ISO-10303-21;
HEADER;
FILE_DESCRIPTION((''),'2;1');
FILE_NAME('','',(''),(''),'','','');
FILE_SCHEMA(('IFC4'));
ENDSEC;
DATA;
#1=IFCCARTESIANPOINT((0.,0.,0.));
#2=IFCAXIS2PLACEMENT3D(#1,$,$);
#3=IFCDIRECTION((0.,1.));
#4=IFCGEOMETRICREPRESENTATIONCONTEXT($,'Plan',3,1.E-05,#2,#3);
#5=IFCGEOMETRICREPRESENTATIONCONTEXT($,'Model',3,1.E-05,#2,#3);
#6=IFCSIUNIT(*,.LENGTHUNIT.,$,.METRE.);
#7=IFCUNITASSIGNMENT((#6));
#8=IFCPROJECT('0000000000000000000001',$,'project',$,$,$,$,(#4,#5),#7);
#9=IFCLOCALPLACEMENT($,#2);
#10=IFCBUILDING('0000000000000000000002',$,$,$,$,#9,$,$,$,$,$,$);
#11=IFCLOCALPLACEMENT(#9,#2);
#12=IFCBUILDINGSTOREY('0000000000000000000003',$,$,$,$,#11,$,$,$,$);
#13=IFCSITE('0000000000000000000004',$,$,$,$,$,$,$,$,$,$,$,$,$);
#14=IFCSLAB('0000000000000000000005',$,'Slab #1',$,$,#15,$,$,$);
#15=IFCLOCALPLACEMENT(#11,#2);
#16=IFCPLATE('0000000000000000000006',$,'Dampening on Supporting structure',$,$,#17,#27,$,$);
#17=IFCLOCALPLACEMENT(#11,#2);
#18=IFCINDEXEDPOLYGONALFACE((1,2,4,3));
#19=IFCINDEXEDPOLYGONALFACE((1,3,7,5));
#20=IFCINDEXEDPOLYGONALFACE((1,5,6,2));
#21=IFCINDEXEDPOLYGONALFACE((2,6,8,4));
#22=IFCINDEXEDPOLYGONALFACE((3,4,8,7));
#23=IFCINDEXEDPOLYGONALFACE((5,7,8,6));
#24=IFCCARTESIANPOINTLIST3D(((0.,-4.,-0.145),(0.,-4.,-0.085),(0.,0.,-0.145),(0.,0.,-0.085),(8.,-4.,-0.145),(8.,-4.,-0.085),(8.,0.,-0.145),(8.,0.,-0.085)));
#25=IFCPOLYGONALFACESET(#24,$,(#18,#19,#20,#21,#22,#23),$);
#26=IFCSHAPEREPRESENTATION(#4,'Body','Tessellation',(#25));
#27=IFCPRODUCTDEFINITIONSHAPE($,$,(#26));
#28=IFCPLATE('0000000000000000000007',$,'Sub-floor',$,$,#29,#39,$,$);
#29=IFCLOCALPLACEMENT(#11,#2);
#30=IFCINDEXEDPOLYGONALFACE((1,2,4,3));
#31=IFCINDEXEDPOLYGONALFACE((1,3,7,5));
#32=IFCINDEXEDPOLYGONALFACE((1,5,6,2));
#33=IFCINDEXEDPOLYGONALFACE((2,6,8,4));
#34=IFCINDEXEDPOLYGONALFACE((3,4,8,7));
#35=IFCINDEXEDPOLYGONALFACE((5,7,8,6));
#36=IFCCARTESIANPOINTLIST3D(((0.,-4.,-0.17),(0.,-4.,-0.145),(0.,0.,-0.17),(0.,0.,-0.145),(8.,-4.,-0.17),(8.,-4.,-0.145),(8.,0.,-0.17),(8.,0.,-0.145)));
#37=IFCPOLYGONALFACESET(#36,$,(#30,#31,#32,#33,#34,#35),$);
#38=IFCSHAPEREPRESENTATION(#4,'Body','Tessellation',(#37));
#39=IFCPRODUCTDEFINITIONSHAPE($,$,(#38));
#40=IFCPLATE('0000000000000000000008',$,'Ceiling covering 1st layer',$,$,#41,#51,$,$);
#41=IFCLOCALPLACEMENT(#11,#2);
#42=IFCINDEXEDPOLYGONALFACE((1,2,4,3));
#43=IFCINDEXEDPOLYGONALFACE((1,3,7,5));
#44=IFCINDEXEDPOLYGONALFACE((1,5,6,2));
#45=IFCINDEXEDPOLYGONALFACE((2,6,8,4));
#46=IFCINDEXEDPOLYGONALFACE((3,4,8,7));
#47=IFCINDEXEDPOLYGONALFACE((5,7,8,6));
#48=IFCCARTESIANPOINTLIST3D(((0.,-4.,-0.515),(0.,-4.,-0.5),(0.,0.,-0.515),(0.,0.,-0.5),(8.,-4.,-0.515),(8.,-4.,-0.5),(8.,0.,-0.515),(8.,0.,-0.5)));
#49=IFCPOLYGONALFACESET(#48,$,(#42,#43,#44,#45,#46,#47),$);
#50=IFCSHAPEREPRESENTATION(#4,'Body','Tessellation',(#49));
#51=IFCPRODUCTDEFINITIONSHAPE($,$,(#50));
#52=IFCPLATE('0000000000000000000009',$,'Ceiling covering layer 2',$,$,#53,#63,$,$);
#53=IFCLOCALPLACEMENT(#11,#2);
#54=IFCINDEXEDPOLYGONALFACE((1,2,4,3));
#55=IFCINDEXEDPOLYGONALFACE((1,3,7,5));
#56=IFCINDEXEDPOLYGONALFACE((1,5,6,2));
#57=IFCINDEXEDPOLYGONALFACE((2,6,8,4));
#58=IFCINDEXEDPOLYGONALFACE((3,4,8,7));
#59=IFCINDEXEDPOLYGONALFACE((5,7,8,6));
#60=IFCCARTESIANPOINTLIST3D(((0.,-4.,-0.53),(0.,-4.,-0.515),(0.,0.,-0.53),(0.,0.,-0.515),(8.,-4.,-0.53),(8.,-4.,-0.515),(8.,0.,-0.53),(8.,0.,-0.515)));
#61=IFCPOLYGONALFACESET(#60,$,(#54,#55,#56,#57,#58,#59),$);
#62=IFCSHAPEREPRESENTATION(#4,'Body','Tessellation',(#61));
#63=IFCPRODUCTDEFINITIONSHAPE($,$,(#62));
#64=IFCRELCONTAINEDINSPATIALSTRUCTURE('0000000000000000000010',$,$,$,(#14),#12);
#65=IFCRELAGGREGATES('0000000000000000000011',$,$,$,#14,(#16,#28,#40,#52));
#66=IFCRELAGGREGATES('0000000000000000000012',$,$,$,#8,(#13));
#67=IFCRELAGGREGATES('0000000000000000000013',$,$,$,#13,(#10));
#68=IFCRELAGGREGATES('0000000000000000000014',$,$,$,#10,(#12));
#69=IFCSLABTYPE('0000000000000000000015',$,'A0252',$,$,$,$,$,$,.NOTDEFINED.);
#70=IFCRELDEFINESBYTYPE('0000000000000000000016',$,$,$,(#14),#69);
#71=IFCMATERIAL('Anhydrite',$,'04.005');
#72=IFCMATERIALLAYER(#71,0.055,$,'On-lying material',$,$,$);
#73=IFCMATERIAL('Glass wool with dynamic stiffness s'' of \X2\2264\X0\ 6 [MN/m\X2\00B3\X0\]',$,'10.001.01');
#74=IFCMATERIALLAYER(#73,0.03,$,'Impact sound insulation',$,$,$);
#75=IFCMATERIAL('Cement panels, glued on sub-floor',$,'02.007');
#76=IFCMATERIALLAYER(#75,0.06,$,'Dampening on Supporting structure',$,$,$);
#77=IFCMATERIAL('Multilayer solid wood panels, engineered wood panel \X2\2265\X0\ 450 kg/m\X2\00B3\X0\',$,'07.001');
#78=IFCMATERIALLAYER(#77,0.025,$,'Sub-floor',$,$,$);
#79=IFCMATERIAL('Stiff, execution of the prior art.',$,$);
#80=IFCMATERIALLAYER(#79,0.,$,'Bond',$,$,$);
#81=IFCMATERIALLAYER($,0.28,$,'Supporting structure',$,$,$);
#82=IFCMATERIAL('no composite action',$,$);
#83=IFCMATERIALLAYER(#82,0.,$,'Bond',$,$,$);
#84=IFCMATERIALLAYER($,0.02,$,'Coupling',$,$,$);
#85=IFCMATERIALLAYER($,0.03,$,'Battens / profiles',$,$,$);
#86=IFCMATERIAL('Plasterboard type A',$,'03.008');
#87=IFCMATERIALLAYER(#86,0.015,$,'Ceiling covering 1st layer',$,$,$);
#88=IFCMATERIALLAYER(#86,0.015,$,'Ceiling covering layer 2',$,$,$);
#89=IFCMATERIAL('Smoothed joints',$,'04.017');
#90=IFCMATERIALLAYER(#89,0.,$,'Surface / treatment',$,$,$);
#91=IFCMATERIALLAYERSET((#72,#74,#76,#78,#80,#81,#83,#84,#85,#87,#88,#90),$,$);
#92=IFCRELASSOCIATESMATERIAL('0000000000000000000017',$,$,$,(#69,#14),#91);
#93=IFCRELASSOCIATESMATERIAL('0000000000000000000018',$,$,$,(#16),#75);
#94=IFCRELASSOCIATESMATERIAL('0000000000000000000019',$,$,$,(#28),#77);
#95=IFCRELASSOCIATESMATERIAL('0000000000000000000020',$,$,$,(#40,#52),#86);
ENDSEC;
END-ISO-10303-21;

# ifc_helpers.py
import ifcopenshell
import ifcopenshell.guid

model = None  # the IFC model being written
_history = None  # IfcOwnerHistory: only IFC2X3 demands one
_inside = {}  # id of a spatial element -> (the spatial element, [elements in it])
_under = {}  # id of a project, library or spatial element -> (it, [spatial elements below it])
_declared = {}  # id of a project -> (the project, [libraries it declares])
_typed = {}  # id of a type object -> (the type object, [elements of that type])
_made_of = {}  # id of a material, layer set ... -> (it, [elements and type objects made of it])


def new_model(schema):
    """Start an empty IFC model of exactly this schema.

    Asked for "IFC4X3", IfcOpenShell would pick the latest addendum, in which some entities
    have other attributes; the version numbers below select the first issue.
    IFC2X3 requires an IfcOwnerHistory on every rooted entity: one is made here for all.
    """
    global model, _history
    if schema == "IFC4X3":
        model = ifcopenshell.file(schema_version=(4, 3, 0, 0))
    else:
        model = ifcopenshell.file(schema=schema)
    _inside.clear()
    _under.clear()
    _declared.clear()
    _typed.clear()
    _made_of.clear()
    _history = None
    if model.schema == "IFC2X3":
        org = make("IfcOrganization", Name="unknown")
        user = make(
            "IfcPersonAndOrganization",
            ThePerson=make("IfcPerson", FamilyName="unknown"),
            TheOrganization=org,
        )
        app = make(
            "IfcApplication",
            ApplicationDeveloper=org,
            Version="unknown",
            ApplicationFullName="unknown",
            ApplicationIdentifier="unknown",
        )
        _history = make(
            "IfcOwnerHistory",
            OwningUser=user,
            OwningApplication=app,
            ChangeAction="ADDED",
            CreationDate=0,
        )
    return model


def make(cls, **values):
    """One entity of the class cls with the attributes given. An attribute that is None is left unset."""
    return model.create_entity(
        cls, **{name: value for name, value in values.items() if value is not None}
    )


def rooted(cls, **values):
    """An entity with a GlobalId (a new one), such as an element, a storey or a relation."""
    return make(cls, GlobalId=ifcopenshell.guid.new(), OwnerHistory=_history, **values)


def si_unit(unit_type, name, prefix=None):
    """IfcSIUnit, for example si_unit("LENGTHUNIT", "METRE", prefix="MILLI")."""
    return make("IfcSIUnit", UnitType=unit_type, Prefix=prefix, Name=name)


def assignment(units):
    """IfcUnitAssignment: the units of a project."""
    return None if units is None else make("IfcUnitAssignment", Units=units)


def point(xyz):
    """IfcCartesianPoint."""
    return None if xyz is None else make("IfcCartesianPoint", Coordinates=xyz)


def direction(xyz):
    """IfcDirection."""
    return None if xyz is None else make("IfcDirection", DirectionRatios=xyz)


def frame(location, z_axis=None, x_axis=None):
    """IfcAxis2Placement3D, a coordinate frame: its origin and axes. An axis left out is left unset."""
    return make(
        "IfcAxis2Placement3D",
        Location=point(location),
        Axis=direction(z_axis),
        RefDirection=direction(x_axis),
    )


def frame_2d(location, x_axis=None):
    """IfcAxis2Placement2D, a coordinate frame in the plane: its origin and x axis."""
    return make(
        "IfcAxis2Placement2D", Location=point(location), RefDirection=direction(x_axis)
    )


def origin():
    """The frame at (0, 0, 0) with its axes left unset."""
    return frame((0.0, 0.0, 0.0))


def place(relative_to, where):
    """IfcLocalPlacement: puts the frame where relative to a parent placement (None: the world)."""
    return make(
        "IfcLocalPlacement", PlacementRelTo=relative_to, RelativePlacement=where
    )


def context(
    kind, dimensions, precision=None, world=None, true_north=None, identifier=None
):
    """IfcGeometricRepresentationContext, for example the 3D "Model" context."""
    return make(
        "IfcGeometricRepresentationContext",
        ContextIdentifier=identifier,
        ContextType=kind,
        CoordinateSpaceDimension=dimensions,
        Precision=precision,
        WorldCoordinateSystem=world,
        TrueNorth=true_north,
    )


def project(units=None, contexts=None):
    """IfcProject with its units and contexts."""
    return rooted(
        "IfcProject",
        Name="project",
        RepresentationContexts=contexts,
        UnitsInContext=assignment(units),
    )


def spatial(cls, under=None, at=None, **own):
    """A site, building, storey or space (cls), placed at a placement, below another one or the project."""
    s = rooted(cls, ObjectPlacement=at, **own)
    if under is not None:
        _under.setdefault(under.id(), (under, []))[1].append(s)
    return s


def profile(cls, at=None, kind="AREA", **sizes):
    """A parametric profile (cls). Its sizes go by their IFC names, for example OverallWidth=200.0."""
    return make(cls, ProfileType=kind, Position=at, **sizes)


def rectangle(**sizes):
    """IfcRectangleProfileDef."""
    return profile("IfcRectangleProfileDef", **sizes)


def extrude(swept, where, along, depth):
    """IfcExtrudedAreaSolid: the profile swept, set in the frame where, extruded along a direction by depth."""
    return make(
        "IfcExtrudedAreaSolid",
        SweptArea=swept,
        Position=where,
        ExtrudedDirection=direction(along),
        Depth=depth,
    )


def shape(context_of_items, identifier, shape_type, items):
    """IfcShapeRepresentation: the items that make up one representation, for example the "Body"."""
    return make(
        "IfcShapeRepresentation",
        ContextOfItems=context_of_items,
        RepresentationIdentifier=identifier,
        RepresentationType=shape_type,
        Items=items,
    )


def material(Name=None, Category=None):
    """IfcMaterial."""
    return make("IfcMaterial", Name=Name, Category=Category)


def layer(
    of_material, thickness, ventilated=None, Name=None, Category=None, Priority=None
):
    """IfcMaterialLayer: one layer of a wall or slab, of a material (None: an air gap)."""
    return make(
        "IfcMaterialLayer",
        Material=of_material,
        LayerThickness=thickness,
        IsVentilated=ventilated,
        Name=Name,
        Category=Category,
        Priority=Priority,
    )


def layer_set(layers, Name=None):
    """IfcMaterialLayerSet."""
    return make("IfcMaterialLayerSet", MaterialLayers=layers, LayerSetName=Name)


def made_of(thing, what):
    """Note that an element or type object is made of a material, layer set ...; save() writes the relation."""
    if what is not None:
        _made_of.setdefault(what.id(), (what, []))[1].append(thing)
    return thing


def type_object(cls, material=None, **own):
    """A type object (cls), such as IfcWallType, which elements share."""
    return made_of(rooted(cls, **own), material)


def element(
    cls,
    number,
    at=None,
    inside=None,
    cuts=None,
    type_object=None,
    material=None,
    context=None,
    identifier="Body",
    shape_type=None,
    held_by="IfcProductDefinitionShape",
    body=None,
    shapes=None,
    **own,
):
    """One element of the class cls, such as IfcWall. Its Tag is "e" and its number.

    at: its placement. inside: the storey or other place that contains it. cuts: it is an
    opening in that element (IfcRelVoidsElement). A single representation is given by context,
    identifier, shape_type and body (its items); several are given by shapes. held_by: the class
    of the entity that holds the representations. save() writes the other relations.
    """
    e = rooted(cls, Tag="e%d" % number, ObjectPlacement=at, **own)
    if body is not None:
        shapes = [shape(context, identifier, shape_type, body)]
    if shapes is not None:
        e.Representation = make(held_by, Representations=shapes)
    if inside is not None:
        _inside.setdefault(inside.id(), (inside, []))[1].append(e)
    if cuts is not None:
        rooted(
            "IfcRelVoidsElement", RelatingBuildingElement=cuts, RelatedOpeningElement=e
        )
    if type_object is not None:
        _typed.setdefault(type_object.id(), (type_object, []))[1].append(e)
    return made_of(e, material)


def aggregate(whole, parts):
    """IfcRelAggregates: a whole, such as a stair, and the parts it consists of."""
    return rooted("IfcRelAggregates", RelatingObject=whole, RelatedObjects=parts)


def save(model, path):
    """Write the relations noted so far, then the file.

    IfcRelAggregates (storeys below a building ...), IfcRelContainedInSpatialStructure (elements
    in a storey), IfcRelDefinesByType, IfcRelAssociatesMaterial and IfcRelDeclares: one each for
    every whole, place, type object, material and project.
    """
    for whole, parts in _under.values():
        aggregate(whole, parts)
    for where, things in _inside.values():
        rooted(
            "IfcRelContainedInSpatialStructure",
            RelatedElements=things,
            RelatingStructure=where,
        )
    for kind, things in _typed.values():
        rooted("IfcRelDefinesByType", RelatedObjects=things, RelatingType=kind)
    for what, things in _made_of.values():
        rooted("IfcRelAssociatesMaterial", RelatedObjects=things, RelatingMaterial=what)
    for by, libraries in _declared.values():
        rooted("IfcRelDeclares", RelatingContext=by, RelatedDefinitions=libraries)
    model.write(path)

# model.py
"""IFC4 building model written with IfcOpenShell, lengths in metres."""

from ifc_helpers import new_model, si_unit, direction, frame, frame_2d, origin, place, context, project, spatial, rectangle, extrude, material, layer, layer_set, type_object, element, aggregate, save


model = new_model("IFC4")

# Units and contexts
plan_context = context("Plan", 3, precision=1e-05, world=origin(), true_north=direction((0.0, 1.0)))
model_context = context("Model", 3, precision=1e-05, world=origin(), true_north=direction((0.0, 1.0)))
ifc_project = project(units=[si_unit("LENGTHUNIT", "METRE")], contexts=[plan_context, model_context])

# Site, building, storey
site = spatial("IfcSite", under=ifc_project)
building_placement = place(None, origin())
building = spatial("IfcBuilding", under=site, at=building_placement)
storey_placement = place(building_placement, origin())
storey = spatial("IfcBuildingStorey", under=building, at=storey_placement)

# Slab, plates
ifc_material_1 = material(Name="Anhydrite", Category="04.005")
ifc_layer_1 = layer(ifc_material_1, 0.055, Name="On-lying material")
ifc_material_2 = material(Name="Glass wool with dynamic stiffness s' of ≤ 6 [MN/m³]", Category="10.001.01")
ifc_layer_2 = layer(ifc_material_2, 0.03, Name="Impact sound insulation")
ifc_material_3 = material(Name="Cement panels, glued on sub-floor", Category="02.007")
ifc_layer_3 = layer(ifc_material_3, 0.06, Name="Dampening on Supporting structure")
ifc_material_4 = material(Name="Multilayer solid wood panels, engineered wood panel ≥ 450 kg/m³", Category="07.001")
ifc_layer_4 = layer(ifc_material_4, 0.025, Name="Sub-floor")
ifc_material_5 = material(Name="Stiff, execution of the prior art.")
ifc_layer_5 = layer(ifc_material_5, 0.0, Name="Bond")
ifc_layer_6 = layer(None, 0.28, Name="Supporting structure")
ifc_material_6 = material(Name="no composite action")
ifc_layer_7 = layer(ifc_material_6, 0.0, Name="Bond")
ifc_layer_8 = layer(None, 0.02, Name="Coupling")
ifc_layer_9 = layer(None, 0.03, Name="Battens / profiles")
ifc_material_7 = material(Name="Plasterboard type A", Category="03.008")
ifc_layer_10 = layer(ifc_material_7, 0.015, Name="Ceiling covering 1st layer")
ifc_layer_11 = layer(ifc_material_7, 0.015, Name="Ceiling covering layer 2")
ifc_material_8 = material(Name="Smoothed joints", Category="04.017")
ifc_layer_12 = layer(ifc_material_8, 0.0, Name="Surface / treatment")
ifc_layer_set = layer_set([ifc_layer_1, ifc_layer_2, ifc_layer_3, ifc_layer_4, ifc_layer_5, ifc_layer_6, ifc_layer_7, ifc_layer_8, ifc_layer_9, ifc_layer_10, ifc_layer_11, ifc_layer_12])
slab_type = type_object("IfcSlabType", Name="A0252", PredefinedType="NOTDEFINED", material=ifc_layer_set)
slab_placement = place(None, frame((0.0, 0.0, 0.0), z_axis=(0.0, 0.0, -1.0), x_axis=(1.0, 0.0, 0.0)))
slab = element("IfcSlab", 1, at=slab_placement, inside=storey, type_object=slab_type, material=ifc_layer_set, Name="Slab #1")
plate_1_placement = place(slab_placement, origin())
plate_1 = element("IfcPlate", 2, at=plate_1_placement, material=ifc_material_3, Name="Dampening on Supporting structure", context=plan_context, shape_type="SweptSolid", body=[
    extrude(rectangle(XDim=8.0, YDim=4.0, at=frame_2d((4.0, 2.0), x_axis=(1.0, 0.0))), frame((0.0, 0.0, 0.085), z_axis=(0.0, 0.0, 1.0), x_axis=(1.0, 0.0, 0.0)), (0.0, 0.0, 1.0), 0.06),
])
plate_2_placement = place(slab_placement, origin())
plate_2 = element("IfcPlate", 3, at=plate_2_placement, material=ifc_material_4, Name="Sub-floor", context=plan_context, shape_type="SweptSolid", body=[
    extrude(rectangle(XDim=8.0, YDim=4.0, at=frame_2d((4.0, 2.0), x_axis=(1.0, 0.0))), frame((0.0, 0.0, 0.145), z_axis=(0.0, 0.0, 1.0), x_axis=(1.0, 0.0, 0.0)), (0.0, 0.0, 1.0), 0.025),
])
plate_3_placement = place(slab_placement, origin())
plate_3 = element("IfcPlate", 4, at=plate_3_placement, material=ifc_material_7, Name="Ceiling covering 1st layer", context=plan_context, shape_type="SweptSolid", body=[
    extrude(rectangle(XDim=8.0, YDim=4.0, at=frame_2d((4.0, 2.0), x_axis=(1.0, 0.0))), frame((0.0, 0.0, 0.5), z_axis=(0.0, 0.0, 1.0), x_axis=(1.0, 0.0, 0.0)), (0.0, 0.0, 1.0), 0.015),
])
plate_4_placement = place(slab_placement, origin())
plate_4 = element("IfcPlate", 5, at=plate_4_placement, material=ifc_material_7, Name="Ceiling covering layer 2", context=plan_context, shape_type="SweptSolid", body=[
    extrude(rectangle(XDim=8.0, YDim=4.0, at=frame_2d((4.0, 2.0), x_axis=(1.0, 0.0))), frame((0.0, 0.0, 0.515), z_axis=(0.0, 0.0, 1.0), x_axis=(1.0, 0.0, 0.0)), (0.0, 0.0, 1.0), 0.015),
])
aggregate(slab, [plate_1, plate_2, plate_3, plate_4])

save(model, "model.ifc")
